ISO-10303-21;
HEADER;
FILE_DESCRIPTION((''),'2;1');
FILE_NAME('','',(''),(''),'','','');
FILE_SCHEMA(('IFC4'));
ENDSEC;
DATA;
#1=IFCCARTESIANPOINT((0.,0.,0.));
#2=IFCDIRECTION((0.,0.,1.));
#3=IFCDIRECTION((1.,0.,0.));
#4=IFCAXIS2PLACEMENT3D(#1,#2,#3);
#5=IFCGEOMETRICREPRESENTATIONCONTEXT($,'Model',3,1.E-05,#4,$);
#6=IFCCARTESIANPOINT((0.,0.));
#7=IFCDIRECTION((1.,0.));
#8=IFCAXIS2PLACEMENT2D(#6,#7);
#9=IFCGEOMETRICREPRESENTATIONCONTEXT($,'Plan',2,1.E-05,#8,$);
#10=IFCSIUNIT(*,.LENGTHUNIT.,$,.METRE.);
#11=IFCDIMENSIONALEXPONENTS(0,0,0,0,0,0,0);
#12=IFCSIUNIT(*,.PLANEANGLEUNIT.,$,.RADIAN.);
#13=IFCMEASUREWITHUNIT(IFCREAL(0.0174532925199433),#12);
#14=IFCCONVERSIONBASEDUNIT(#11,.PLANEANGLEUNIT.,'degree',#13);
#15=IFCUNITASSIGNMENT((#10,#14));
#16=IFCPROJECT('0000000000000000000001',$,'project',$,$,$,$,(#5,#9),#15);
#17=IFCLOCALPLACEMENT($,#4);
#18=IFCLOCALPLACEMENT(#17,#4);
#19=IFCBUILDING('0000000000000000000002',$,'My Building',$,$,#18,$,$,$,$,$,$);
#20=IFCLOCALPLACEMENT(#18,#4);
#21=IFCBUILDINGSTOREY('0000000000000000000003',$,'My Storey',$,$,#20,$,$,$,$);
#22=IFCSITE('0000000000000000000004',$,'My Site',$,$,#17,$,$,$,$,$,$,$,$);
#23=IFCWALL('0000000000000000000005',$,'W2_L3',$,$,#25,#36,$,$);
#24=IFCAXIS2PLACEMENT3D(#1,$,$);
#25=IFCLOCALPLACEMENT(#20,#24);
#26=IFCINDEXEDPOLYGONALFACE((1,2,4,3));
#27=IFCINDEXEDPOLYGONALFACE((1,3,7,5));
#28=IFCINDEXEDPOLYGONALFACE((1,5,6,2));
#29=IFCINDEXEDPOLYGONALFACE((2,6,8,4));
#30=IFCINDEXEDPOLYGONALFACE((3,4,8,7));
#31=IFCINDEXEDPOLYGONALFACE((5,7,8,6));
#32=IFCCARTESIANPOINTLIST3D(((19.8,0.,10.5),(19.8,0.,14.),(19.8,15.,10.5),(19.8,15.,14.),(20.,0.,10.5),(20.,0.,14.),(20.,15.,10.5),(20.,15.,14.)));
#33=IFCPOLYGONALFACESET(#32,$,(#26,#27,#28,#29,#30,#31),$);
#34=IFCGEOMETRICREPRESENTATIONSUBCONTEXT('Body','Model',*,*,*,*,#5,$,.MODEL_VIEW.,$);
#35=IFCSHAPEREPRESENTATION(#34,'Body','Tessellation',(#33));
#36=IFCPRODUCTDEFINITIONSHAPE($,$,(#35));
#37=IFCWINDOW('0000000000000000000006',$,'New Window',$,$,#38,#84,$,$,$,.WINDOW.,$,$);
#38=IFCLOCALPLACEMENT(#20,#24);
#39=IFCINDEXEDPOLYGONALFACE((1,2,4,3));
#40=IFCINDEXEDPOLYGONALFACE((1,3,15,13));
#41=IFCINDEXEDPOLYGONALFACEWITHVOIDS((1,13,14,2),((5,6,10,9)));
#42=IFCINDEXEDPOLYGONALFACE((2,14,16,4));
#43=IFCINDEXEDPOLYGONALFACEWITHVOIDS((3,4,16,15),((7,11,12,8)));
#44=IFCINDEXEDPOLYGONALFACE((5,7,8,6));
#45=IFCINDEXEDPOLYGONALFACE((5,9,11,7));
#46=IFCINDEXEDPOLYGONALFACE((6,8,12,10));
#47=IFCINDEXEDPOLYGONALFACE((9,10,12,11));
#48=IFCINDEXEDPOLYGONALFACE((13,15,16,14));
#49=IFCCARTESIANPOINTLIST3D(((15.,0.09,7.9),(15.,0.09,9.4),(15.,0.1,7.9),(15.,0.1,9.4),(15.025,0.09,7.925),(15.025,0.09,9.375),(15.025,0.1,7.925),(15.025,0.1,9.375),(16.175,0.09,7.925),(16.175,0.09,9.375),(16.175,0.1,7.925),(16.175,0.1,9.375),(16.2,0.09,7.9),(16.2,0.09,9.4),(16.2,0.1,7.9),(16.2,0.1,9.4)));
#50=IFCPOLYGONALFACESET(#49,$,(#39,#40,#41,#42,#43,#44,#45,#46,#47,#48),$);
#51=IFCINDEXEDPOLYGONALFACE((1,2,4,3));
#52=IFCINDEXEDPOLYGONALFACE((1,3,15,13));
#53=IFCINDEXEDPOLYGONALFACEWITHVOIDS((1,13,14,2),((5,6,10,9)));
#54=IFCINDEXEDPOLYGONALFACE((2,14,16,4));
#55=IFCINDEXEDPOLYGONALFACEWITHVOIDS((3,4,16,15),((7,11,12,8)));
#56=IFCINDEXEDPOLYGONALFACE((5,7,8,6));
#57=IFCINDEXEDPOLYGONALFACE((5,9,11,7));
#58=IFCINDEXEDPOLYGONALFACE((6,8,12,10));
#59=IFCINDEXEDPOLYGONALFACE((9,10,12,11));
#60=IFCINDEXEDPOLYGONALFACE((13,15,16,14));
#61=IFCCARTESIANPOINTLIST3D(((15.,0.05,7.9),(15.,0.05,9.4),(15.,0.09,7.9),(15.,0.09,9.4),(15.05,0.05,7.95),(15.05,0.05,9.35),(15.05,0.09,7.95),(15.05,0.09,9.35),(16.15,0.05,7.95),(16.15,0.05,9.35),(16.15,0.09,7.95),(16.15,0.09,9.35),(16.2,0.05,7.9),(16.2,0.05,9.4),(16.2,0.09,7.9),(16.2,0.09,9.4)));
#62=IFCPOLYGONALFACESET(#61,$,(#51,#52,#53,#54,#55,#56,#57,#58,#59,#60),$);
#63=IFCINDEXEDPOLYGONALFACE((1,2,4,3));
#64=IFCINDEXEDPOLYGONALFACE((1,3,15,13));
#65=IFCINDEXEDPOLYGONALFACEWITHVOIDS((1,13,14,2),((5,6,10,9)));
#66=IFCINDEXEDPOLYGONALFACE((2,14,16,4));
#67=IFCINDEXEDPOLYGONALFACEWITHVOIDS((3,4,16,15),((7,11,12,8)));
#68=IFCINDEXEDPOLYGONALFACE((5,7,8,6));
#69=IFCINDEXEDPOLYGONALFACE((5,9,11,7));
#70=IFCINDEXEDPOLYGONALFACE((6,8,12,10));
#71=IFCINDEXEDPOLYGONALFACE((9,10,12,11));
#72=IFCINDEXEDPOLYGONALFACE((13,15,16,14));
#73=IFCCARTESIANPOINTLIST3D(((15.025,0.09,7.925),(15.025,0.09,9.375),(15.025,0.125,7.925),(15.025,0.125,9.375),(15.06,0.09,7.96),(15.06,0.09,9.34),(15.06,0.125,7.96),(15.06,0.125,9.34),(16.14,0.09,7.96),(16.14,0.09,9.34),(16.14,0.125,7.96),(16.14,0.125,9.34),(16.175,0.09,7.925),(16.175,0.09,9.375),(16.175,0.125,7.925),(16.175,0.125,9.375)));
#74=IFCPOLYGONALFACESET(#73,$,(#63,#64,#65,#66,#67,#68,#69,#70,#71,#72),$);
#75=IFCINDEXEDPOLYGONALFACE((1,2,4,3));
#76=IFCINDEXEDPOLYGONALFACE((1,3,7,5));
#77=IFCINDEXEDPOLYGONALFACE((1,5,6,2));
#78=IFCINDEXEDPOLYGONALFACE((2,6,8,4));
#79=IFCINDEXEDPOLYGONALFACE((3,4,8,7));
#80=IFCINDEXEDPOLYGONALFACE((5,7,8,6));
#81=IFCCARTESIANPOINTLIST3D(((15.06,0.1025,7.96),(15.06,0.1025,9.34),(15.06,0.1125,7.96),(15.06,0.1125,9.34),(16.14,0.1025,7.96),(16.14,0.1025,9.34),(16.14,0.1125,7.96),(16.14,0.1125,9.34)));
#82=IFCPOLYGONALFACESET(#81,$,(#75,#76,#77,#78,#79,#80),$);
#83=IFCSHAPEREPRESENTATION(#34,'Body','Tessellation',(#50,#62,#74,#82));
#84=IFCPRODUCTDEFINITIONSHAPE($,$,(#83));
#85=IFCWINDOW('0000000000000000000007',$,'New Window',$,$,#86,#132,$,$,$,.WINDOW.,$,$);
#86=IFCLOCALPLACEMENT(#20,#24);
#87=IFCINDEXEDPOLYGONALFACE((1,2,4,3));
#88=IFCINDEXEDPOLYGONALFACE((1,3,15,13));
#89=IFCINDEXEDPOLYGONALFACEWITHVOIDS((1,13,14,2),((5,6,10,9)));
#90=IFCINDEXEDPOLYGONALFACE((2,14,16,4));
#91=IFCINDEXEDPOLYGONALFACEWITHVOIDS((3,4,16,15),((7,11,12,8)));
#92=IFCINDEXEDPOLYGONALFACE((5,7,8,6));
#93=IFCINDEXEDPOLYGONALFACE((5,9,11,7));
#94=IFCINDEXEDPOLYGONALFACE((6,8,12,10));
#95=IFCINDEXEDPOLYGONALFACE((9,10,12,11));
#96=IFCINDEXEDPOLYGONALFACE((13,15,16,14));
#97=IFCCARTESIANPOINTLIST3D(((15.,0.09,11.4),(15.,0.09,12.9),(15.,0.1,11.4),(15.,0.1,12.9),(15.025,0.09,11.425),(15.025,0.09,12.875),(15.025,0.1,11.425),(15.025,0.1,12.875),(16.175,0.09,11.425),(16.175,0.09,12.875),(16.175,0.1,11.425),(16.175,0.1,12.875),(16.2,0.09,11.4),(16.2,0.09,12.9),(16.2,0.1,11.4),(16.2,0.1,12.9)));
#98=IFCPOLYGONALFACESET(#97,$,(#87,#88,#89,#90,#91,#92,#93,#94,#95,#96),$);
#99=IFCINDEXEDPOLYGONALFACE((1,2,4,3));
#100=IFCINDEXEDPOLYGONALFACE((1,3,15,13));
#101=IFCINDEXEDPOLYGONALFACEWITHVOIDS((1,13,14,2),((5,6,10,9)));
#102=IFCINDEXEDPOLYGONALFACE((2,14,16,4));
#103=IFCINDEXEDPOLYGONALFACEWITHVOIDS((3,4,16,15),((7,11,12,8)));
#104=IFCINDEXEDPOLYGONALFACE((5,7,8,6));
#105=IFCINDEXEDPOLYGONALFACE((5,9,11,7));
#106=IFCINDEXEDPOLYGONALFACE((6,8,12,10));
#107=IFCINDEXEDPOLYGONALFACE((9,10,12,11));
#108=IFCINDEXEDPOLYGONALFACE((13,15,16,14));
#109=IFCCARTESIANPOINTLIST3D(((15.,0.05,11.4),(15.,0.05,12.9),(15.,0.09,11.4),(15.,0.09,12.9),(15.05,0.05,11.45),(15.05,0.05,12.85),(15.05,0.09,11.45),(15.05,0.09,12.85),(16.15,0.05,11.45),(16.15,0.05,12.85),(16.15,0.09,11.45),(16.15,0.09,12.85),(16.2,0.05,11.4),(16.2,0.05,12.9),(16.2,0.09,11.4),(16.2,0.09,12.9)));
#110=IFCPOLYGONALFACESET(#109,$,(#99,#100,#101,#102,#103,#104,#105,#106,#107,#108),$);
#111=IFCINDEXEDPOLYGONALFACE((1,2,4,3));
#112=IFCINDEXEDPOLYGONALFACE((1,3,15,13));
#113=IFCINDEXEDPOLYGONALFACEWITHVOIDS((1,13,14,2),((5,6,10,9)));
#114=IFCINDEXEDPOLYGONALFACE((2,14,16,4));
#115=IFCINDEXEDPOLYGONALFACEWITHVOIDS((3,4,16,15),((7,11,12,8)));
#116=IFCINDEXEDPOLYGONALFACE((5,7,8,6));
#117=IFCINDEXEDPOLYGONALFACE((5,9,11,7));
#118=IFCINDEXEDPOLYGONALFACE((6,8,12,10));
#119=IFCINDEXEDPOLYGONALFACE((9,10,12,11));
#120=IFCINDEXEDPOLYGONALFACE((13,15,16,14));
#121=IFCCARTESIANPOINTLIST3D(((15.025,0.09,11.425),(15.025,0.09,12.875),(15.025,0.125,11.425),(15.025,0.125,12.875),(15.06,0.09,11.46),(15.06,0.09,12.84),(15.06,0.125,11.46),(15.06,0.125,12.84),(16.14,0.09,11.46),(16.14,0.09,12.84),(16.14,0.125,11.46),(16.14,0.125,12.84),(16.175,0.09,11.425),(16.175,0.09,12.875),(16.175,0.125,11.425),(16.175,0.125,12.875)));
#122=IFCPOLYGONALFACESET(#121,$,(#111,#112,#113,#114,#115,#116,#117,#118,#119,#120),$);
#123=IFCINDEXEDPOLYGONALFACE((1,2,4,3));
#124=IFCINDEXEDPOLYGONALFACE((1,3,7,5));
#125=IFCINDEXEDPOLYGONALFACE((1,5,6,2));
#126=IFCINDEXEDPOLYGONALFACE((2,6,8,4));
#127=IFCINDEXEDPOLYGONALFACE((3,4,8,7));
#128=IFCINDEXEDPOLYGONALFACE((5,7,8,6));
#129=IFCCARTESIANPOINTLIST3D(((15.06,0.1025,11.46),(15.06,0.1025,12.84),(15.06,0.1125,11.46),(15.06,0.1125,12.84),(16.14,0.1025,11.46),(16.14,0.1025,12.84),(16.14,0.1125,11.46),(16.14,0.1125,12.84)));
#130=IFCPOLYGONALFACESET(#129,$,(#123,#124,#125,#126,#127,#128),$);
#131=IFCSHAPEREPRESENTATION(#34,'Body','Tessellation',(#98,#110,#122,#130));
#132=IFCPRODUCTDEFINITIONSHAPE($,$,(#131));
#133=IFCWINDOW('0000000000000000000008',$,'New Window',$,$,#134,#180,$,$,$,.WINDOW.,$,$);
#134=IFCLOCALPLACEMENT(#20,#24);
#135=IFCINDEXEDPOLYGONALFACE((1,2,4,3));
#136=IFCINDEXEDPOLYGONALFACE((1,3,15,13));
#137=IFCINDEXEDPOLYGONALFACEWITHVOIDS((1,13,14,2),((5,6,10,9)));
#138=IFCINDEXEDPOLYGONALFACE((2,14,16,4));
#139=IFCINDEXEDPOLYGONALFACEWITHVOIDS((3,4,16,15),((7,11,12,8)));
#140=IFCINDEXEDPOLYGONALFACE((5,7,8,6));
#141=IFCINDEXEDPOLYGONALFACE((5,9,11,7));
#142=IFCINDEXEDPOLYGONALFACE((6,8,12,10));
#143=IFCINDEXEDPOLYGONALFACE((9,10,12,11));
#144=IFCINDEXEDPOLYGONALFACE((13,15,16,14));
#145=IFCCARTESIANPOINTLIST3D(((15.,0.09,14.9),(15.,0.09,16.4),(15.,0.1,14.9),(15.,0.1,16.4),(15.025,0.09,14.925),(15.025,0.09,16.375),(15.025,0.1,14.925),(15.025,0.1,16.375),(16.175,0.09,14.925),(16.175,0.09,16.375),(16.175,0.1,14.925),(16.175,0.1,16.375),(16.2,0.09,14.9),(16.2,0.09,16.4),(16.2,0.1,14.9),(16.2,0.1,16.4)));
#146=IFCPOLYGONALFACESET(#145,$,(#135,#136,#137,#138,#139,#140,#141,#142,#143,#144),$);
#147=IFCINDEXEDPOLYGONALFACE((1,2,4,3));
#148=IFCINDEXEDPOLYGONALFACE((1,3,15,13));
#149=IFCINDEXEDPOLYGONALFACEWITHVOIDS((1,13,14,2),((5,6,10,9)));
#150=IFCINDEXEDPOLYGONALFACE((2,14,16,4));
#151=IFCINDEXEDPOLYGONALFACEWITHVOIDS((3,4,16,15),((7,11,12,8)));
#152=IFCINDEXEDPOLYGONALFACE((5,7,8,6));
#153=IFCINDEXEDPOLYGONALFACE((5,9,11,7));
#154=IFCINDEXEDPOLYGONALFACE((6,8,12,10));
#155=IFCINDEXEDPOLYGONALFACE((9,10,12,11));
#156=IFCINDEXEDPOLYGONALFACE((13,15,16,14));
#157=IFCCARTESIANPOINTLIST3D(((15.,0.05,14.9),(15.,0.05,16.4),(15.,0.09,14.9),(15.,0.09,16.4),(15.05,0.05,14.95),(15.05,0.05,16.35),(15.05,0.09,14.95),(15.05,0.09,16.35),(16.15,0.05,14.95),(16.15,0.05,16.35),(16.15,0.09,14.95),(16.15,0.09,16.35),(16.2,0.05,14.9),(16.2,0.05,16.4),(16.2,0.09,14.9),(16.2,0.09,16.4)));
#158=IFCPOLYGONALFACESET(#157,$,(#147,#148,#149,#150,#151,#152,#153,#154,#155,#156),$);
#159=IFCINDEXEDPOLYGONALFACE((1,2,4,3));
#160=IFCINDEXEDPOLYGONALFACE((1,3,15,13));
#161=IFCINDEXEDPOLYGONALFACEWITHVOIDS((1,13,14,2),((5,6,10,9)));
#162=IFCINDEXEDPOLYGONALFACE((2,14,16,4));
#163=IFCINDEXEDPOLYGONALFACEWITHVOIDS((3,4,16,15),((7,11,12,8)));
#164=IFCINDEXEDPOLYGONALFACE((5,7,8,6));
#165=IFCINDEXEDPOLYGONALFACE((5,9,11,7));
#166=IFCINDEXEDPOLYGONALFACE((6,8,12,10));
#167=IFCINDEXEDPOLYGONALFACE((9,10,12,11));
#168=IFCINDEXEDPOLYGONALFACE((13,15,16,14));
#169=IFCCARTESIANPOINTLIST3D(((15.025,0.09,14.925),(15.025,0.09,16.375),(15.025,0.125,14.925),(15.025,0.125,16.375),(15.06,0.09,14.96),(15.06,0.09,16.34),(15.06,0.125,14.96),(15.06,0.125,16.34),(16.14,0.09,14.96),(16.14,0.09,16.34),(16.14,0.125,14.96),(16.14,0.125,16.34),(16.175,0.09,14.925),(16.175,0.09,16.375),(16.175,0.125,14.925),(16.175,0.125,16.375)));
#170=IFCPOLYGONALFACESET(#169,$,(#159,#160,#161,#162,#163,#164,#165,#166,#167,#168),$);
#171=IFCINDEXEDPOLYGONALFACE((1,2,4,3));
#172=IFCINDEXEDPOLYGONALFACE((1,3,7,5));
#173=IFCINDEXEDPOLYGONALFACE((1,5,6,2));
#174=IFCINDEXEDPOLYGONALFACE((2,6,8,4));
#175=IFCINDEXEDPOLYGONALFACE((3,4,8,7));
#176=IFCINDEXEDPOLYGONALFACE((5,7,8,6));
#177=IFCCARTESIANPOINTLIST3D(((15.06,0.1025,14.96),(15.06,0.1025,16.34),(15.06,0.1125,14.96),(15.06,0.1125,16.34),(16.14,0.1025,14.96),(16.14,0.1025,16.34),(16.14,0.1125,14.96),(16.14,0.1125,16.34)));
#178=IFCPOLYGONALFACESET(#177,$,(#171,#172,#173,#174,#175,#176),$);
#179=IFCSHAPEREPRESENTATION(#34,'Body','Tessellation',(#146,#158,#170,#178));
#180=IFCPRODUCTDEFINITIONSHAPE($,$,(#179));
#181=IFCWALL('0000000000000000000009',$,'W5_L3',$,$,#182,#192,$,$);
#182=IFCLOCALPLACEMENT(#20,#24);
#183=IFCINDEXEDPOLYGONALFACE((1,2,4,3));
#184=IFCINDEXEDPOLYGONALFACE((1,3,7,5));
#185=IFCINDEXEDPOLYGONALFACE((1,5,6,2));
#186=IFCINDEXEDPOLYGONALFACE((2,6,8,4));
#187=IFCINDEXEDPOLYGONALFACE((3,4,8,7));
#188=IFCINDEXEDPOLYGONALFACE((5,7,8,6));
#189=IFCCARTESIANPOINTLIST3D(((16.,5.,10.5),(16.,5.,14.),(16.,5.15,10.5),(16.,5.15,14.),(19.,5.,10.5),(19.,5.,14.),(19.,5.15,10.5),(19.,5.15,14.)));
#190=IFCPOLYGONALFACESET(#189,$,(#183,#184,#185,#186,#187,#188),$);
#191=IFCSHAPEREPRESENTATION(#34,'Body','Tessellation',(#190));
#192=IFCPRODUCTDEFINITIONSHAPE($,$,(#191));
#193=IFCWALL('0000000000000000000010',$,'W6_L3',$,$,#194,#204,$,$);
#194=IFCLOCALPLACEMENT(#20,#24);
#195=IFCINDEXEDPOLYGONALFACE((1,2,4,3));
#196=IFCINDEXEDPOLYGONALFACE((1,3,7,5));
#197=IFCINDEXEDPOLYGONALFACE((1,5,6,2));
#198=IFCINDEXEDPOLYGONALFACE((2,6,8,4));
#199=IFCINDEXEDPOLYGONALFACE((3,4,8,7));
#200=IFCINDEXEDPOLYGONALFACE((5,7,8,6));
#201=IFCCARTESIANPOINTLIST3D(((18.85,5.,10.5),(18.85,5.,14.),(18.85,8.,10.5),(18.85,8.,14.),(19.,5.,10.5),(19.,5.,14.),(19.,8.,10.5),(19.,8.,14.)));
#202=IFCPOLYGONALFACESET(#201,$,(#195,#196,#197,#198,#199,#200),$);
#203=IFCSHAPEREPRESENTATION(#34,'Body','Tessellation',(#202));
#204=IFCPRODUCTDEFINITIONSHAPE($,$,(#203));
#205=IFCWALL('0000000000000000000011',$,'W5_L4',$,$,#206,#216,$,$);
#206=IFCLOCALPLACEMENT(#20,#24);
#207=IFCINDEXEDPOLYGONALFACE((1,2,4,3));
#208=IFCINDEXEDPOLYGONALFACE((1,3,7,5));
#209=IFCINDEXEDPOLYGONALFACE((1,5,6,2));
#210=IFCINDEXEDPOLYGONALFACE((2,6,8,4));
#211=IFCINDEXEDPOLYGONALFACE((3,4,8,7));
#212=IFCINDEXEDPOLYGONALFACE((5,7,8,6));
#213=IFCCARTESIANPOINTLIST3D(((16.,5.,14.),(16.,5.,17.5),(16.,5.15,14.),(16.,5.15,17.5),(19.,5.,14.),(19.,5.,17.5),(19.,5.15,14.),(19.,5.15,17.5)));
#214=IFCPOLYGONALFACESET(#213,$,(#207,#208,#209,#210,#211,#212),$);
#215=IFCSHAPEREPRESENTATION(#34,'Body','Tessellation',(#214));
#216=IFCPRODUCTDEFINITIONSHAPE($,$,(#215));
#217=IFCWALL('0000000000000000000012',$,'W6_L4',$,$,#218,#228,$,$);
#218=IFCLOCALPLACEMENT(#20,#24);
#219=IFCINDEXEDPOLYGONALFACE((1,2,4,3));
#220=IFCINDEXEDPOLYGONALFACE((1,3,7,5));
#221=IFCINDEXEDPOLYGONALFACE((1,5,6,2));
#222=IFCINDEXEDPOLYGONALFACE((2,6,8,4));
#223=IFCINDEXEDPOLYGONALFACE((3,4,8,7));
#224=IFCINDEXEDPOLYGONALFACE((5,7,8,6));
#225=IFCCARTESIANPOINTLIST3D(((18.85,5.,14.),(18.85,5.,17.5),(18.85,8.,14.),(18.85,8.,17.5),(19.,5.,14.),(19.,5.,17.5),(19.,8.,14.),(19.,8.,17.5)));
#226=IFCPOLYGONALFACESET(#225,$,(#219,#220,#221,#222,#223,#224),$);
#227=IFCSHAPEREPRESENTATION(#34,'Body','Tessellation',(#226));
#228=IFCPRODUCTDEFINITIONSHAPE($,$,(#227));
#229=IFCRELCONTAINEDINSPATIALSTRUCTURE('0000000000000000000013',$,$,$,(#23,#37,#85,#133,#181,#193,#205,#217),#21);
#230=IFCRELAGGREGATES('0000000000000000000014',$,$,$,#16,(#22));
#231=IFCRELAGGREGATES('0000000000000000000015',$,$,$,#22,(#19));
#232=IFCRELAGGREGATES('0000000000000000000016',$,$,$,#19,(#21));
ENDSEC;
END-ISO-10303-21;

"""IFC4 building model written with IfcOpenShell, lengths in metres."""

from ifc_helpers import new_model, entity, si_unit, converted_unit, frame, origin_with_axes, origin_2d_with_axis, place, context, subcontext, project, spatial, line, indexed_curve, outline, extrude, element, save


model = new_model("IFC4")

# Units and contexts
model_context = context("Model", 3, precision=1e-05, world=origin_with_axes())
plan_context = context("Plan", 2, precision=1e-05, world=origin_2d_with_axis())
body_context = subcontext(model_context, "Body", "Model", "MODEL_VIEW")
ifc_project = project(units=[si_unit("LENGTHUNIT", "METRE"), converted_unit("PLANEANGLEUNIT", "degree", entity("IfcReal", 0.0174532925199433), si_unit("PLANEANGLEUNIT", "RADIAN"), dimensions=[0, 0, 0, 0, 0, 0, 0])], contexts=[model_context, plan_context])

# Site, building, storey
site_placement = place(None, origin_with_axes())
site = spatial("IfcSite", under=ifc_project, at=site_placement, Name="My Site")
building_placement = place(site_placement, origin_with_axes())
building = spatial("IfcBuilding", under=site, at=building_placement, Name="My Building")
storey_placement = place(building_placement, origin_with_axes())
storey = spatial("IfcBuildingStorey", under=building, at=storey_placement, Name="My Storey")

# Wall
for number, where, z_axis, x_axis, name in (
    (1, (20.0, 0.0, 10.5), (0.0, 0.0, 1.0), (0.0, 1.0, 0.0), "W2_L3"),
):
    element("IfcWall", number, at=place(storey_placement, frame(where, z_axis=z_axis, x_axis=x_axis)), inside=storey, Name=name, context=body_context, shape_type="SweptSolid", body=[
        extrude(outline(indexed_curve([(0.0, 0.0), (0.0, 0.2), (15.0, 0.2), (15.0, 0.0), (0.0, 0.0)], self_intersect=False)), origin_with_axes(), (0.0, 0.0, 1.0), 3.5),
    ])

# Windows
for number, where, z_axis, x_axis, name in (
    (2, (15.0, 0.0, 7.9), (0.0, 0.0, 1.0), (1.0, 0.0, 0.0), "New Window"),
    (3, (15.0, 0.0, 11.4), (0.0, 0.0, 1.0), (1.0, 0.0, 0.0), "New Window"),
    (4, (15.0, 0.0, 14.9), (0.0, 0.0, 1.0), (1.0, 0.0, 0.0), "New Window"),
):
    element("IfcWindow", number, at=place(storey_placement, frame(where, z_axis=z_axis, x_axis=x_axis)), inside=storey, Name=name, PredefinedType="WINDOW", context=body_context, shape_type="SweptSolid", body=[
        extrude(outline(indexed_curve([(0.0, 0.0), (1.2, 0.0), (1.2, 1.5), (0.0, 1.5)], segments=[line(1, 2, 3, 4, 1)]), holes=[indexed_curve([(0.025, 0.025), (1.175, 0.025), (1.175, 1.475), (0.025, 1.475)], segments=[line(1, 2, 3, 4, 1)])]), frame((0.0, 0.09, 0.0), z_axis=(0.0, -1.0, 0.0), x_axis=(1.0, 0.0, 0.0)), (0.0, 0.0, -1.0), 0.01),
        extrude(outline(indexed_curve([(0.0, 0.0), (1.2, 0.0), (1.2, 1.5), (0.0, 1.5)], segments=[line(1, 2, 3, 4, 1)]), holes=[indexed_curve([(0.05, 0.05), (1.15, 0.05), (1.15, 1.45), (0.05, 1.45)], segments=[line(1, 2, 3, 4, 1)])]), frame((0.0, 0.05, 0.0), z_axis=(0.0, -1.0, 0.0), x_axis=(1.0, 0.0, 0.0)), (0.0, 0.0, -1.0), 0.04),
        extrude(outline(indexed_curve([(0.0, 0.0), (1.15, 0.0), (1.15, 1.45), (0.0, 1.45)], segments=[line(1, 2, 3, 4, 1)]), holes=[indexed_curve([(0.035, 0.035), (1.115, 0.035), (1.115, 1.415), (0.035, 1.415)], segments=[line(1, 2, 3, 4, 1)])]), frame((0.025, 0.09, 0.025), z_axis=(0.0, -1.0, 0.0), x_axis=(1.0, 0.0, 0.0)), (0.0, 0.0, -1.0), 0.035),
        extrude(outline(indexed_curve([(0.035, 0.035), (1.115, 0.035), (1.115, 1.415), (0.035, 1.415)], segments=[line(1, 2, 3, 4, 1)])), frame((0.025, 0.1025, 0.025), z_axis=(0.0, -1.0, 0.0), x_axis=(1.0, 0.0, 0.0)), (0.0, 0.0, -1.0), 0.01),
    ])

# Walls
for number, where, z_axis, x_axis, name in (
    (5, (16.0, 5.0, 10.5), (0.0, 0.0, 1.0), (1.0, 0.0, 0.0), "W5_L3"),
    (6, (19.0, 5.0, 10.5), (0.0, 0.0, 1.0), (0.0, 1.0, 0.0), "W6_L3"),
    (7, (16.0, 5.0, 14.0), (0.0, 0.0, 1.0), (1.0, 0.0, 0.0), "W5_L4"),
    (8, (19.0, 5.0, 14.0), (0.0, 0.0, 1.0), (0.0, 1.0, 0.0), "W6_L4"),
):
    element("IfcWall", number, at=place(storey_placement, frame(where, z_axis=z_axis, x_axis=x_axis)), inside=storey, Name=name, context=body_context, shape_type="SweptSolid", body=[
        extrude(outline(indexed_curve([(0.0, 0.0), (0.0, 0.15), (3.0, 0.15), (3.0, 0.0), (0.0, 0.0)], self_intersect=False)), origin_with_axes(), (0.0, 0.0, 1.0), 3.5),
    ])

save(model, "model.ifc")
